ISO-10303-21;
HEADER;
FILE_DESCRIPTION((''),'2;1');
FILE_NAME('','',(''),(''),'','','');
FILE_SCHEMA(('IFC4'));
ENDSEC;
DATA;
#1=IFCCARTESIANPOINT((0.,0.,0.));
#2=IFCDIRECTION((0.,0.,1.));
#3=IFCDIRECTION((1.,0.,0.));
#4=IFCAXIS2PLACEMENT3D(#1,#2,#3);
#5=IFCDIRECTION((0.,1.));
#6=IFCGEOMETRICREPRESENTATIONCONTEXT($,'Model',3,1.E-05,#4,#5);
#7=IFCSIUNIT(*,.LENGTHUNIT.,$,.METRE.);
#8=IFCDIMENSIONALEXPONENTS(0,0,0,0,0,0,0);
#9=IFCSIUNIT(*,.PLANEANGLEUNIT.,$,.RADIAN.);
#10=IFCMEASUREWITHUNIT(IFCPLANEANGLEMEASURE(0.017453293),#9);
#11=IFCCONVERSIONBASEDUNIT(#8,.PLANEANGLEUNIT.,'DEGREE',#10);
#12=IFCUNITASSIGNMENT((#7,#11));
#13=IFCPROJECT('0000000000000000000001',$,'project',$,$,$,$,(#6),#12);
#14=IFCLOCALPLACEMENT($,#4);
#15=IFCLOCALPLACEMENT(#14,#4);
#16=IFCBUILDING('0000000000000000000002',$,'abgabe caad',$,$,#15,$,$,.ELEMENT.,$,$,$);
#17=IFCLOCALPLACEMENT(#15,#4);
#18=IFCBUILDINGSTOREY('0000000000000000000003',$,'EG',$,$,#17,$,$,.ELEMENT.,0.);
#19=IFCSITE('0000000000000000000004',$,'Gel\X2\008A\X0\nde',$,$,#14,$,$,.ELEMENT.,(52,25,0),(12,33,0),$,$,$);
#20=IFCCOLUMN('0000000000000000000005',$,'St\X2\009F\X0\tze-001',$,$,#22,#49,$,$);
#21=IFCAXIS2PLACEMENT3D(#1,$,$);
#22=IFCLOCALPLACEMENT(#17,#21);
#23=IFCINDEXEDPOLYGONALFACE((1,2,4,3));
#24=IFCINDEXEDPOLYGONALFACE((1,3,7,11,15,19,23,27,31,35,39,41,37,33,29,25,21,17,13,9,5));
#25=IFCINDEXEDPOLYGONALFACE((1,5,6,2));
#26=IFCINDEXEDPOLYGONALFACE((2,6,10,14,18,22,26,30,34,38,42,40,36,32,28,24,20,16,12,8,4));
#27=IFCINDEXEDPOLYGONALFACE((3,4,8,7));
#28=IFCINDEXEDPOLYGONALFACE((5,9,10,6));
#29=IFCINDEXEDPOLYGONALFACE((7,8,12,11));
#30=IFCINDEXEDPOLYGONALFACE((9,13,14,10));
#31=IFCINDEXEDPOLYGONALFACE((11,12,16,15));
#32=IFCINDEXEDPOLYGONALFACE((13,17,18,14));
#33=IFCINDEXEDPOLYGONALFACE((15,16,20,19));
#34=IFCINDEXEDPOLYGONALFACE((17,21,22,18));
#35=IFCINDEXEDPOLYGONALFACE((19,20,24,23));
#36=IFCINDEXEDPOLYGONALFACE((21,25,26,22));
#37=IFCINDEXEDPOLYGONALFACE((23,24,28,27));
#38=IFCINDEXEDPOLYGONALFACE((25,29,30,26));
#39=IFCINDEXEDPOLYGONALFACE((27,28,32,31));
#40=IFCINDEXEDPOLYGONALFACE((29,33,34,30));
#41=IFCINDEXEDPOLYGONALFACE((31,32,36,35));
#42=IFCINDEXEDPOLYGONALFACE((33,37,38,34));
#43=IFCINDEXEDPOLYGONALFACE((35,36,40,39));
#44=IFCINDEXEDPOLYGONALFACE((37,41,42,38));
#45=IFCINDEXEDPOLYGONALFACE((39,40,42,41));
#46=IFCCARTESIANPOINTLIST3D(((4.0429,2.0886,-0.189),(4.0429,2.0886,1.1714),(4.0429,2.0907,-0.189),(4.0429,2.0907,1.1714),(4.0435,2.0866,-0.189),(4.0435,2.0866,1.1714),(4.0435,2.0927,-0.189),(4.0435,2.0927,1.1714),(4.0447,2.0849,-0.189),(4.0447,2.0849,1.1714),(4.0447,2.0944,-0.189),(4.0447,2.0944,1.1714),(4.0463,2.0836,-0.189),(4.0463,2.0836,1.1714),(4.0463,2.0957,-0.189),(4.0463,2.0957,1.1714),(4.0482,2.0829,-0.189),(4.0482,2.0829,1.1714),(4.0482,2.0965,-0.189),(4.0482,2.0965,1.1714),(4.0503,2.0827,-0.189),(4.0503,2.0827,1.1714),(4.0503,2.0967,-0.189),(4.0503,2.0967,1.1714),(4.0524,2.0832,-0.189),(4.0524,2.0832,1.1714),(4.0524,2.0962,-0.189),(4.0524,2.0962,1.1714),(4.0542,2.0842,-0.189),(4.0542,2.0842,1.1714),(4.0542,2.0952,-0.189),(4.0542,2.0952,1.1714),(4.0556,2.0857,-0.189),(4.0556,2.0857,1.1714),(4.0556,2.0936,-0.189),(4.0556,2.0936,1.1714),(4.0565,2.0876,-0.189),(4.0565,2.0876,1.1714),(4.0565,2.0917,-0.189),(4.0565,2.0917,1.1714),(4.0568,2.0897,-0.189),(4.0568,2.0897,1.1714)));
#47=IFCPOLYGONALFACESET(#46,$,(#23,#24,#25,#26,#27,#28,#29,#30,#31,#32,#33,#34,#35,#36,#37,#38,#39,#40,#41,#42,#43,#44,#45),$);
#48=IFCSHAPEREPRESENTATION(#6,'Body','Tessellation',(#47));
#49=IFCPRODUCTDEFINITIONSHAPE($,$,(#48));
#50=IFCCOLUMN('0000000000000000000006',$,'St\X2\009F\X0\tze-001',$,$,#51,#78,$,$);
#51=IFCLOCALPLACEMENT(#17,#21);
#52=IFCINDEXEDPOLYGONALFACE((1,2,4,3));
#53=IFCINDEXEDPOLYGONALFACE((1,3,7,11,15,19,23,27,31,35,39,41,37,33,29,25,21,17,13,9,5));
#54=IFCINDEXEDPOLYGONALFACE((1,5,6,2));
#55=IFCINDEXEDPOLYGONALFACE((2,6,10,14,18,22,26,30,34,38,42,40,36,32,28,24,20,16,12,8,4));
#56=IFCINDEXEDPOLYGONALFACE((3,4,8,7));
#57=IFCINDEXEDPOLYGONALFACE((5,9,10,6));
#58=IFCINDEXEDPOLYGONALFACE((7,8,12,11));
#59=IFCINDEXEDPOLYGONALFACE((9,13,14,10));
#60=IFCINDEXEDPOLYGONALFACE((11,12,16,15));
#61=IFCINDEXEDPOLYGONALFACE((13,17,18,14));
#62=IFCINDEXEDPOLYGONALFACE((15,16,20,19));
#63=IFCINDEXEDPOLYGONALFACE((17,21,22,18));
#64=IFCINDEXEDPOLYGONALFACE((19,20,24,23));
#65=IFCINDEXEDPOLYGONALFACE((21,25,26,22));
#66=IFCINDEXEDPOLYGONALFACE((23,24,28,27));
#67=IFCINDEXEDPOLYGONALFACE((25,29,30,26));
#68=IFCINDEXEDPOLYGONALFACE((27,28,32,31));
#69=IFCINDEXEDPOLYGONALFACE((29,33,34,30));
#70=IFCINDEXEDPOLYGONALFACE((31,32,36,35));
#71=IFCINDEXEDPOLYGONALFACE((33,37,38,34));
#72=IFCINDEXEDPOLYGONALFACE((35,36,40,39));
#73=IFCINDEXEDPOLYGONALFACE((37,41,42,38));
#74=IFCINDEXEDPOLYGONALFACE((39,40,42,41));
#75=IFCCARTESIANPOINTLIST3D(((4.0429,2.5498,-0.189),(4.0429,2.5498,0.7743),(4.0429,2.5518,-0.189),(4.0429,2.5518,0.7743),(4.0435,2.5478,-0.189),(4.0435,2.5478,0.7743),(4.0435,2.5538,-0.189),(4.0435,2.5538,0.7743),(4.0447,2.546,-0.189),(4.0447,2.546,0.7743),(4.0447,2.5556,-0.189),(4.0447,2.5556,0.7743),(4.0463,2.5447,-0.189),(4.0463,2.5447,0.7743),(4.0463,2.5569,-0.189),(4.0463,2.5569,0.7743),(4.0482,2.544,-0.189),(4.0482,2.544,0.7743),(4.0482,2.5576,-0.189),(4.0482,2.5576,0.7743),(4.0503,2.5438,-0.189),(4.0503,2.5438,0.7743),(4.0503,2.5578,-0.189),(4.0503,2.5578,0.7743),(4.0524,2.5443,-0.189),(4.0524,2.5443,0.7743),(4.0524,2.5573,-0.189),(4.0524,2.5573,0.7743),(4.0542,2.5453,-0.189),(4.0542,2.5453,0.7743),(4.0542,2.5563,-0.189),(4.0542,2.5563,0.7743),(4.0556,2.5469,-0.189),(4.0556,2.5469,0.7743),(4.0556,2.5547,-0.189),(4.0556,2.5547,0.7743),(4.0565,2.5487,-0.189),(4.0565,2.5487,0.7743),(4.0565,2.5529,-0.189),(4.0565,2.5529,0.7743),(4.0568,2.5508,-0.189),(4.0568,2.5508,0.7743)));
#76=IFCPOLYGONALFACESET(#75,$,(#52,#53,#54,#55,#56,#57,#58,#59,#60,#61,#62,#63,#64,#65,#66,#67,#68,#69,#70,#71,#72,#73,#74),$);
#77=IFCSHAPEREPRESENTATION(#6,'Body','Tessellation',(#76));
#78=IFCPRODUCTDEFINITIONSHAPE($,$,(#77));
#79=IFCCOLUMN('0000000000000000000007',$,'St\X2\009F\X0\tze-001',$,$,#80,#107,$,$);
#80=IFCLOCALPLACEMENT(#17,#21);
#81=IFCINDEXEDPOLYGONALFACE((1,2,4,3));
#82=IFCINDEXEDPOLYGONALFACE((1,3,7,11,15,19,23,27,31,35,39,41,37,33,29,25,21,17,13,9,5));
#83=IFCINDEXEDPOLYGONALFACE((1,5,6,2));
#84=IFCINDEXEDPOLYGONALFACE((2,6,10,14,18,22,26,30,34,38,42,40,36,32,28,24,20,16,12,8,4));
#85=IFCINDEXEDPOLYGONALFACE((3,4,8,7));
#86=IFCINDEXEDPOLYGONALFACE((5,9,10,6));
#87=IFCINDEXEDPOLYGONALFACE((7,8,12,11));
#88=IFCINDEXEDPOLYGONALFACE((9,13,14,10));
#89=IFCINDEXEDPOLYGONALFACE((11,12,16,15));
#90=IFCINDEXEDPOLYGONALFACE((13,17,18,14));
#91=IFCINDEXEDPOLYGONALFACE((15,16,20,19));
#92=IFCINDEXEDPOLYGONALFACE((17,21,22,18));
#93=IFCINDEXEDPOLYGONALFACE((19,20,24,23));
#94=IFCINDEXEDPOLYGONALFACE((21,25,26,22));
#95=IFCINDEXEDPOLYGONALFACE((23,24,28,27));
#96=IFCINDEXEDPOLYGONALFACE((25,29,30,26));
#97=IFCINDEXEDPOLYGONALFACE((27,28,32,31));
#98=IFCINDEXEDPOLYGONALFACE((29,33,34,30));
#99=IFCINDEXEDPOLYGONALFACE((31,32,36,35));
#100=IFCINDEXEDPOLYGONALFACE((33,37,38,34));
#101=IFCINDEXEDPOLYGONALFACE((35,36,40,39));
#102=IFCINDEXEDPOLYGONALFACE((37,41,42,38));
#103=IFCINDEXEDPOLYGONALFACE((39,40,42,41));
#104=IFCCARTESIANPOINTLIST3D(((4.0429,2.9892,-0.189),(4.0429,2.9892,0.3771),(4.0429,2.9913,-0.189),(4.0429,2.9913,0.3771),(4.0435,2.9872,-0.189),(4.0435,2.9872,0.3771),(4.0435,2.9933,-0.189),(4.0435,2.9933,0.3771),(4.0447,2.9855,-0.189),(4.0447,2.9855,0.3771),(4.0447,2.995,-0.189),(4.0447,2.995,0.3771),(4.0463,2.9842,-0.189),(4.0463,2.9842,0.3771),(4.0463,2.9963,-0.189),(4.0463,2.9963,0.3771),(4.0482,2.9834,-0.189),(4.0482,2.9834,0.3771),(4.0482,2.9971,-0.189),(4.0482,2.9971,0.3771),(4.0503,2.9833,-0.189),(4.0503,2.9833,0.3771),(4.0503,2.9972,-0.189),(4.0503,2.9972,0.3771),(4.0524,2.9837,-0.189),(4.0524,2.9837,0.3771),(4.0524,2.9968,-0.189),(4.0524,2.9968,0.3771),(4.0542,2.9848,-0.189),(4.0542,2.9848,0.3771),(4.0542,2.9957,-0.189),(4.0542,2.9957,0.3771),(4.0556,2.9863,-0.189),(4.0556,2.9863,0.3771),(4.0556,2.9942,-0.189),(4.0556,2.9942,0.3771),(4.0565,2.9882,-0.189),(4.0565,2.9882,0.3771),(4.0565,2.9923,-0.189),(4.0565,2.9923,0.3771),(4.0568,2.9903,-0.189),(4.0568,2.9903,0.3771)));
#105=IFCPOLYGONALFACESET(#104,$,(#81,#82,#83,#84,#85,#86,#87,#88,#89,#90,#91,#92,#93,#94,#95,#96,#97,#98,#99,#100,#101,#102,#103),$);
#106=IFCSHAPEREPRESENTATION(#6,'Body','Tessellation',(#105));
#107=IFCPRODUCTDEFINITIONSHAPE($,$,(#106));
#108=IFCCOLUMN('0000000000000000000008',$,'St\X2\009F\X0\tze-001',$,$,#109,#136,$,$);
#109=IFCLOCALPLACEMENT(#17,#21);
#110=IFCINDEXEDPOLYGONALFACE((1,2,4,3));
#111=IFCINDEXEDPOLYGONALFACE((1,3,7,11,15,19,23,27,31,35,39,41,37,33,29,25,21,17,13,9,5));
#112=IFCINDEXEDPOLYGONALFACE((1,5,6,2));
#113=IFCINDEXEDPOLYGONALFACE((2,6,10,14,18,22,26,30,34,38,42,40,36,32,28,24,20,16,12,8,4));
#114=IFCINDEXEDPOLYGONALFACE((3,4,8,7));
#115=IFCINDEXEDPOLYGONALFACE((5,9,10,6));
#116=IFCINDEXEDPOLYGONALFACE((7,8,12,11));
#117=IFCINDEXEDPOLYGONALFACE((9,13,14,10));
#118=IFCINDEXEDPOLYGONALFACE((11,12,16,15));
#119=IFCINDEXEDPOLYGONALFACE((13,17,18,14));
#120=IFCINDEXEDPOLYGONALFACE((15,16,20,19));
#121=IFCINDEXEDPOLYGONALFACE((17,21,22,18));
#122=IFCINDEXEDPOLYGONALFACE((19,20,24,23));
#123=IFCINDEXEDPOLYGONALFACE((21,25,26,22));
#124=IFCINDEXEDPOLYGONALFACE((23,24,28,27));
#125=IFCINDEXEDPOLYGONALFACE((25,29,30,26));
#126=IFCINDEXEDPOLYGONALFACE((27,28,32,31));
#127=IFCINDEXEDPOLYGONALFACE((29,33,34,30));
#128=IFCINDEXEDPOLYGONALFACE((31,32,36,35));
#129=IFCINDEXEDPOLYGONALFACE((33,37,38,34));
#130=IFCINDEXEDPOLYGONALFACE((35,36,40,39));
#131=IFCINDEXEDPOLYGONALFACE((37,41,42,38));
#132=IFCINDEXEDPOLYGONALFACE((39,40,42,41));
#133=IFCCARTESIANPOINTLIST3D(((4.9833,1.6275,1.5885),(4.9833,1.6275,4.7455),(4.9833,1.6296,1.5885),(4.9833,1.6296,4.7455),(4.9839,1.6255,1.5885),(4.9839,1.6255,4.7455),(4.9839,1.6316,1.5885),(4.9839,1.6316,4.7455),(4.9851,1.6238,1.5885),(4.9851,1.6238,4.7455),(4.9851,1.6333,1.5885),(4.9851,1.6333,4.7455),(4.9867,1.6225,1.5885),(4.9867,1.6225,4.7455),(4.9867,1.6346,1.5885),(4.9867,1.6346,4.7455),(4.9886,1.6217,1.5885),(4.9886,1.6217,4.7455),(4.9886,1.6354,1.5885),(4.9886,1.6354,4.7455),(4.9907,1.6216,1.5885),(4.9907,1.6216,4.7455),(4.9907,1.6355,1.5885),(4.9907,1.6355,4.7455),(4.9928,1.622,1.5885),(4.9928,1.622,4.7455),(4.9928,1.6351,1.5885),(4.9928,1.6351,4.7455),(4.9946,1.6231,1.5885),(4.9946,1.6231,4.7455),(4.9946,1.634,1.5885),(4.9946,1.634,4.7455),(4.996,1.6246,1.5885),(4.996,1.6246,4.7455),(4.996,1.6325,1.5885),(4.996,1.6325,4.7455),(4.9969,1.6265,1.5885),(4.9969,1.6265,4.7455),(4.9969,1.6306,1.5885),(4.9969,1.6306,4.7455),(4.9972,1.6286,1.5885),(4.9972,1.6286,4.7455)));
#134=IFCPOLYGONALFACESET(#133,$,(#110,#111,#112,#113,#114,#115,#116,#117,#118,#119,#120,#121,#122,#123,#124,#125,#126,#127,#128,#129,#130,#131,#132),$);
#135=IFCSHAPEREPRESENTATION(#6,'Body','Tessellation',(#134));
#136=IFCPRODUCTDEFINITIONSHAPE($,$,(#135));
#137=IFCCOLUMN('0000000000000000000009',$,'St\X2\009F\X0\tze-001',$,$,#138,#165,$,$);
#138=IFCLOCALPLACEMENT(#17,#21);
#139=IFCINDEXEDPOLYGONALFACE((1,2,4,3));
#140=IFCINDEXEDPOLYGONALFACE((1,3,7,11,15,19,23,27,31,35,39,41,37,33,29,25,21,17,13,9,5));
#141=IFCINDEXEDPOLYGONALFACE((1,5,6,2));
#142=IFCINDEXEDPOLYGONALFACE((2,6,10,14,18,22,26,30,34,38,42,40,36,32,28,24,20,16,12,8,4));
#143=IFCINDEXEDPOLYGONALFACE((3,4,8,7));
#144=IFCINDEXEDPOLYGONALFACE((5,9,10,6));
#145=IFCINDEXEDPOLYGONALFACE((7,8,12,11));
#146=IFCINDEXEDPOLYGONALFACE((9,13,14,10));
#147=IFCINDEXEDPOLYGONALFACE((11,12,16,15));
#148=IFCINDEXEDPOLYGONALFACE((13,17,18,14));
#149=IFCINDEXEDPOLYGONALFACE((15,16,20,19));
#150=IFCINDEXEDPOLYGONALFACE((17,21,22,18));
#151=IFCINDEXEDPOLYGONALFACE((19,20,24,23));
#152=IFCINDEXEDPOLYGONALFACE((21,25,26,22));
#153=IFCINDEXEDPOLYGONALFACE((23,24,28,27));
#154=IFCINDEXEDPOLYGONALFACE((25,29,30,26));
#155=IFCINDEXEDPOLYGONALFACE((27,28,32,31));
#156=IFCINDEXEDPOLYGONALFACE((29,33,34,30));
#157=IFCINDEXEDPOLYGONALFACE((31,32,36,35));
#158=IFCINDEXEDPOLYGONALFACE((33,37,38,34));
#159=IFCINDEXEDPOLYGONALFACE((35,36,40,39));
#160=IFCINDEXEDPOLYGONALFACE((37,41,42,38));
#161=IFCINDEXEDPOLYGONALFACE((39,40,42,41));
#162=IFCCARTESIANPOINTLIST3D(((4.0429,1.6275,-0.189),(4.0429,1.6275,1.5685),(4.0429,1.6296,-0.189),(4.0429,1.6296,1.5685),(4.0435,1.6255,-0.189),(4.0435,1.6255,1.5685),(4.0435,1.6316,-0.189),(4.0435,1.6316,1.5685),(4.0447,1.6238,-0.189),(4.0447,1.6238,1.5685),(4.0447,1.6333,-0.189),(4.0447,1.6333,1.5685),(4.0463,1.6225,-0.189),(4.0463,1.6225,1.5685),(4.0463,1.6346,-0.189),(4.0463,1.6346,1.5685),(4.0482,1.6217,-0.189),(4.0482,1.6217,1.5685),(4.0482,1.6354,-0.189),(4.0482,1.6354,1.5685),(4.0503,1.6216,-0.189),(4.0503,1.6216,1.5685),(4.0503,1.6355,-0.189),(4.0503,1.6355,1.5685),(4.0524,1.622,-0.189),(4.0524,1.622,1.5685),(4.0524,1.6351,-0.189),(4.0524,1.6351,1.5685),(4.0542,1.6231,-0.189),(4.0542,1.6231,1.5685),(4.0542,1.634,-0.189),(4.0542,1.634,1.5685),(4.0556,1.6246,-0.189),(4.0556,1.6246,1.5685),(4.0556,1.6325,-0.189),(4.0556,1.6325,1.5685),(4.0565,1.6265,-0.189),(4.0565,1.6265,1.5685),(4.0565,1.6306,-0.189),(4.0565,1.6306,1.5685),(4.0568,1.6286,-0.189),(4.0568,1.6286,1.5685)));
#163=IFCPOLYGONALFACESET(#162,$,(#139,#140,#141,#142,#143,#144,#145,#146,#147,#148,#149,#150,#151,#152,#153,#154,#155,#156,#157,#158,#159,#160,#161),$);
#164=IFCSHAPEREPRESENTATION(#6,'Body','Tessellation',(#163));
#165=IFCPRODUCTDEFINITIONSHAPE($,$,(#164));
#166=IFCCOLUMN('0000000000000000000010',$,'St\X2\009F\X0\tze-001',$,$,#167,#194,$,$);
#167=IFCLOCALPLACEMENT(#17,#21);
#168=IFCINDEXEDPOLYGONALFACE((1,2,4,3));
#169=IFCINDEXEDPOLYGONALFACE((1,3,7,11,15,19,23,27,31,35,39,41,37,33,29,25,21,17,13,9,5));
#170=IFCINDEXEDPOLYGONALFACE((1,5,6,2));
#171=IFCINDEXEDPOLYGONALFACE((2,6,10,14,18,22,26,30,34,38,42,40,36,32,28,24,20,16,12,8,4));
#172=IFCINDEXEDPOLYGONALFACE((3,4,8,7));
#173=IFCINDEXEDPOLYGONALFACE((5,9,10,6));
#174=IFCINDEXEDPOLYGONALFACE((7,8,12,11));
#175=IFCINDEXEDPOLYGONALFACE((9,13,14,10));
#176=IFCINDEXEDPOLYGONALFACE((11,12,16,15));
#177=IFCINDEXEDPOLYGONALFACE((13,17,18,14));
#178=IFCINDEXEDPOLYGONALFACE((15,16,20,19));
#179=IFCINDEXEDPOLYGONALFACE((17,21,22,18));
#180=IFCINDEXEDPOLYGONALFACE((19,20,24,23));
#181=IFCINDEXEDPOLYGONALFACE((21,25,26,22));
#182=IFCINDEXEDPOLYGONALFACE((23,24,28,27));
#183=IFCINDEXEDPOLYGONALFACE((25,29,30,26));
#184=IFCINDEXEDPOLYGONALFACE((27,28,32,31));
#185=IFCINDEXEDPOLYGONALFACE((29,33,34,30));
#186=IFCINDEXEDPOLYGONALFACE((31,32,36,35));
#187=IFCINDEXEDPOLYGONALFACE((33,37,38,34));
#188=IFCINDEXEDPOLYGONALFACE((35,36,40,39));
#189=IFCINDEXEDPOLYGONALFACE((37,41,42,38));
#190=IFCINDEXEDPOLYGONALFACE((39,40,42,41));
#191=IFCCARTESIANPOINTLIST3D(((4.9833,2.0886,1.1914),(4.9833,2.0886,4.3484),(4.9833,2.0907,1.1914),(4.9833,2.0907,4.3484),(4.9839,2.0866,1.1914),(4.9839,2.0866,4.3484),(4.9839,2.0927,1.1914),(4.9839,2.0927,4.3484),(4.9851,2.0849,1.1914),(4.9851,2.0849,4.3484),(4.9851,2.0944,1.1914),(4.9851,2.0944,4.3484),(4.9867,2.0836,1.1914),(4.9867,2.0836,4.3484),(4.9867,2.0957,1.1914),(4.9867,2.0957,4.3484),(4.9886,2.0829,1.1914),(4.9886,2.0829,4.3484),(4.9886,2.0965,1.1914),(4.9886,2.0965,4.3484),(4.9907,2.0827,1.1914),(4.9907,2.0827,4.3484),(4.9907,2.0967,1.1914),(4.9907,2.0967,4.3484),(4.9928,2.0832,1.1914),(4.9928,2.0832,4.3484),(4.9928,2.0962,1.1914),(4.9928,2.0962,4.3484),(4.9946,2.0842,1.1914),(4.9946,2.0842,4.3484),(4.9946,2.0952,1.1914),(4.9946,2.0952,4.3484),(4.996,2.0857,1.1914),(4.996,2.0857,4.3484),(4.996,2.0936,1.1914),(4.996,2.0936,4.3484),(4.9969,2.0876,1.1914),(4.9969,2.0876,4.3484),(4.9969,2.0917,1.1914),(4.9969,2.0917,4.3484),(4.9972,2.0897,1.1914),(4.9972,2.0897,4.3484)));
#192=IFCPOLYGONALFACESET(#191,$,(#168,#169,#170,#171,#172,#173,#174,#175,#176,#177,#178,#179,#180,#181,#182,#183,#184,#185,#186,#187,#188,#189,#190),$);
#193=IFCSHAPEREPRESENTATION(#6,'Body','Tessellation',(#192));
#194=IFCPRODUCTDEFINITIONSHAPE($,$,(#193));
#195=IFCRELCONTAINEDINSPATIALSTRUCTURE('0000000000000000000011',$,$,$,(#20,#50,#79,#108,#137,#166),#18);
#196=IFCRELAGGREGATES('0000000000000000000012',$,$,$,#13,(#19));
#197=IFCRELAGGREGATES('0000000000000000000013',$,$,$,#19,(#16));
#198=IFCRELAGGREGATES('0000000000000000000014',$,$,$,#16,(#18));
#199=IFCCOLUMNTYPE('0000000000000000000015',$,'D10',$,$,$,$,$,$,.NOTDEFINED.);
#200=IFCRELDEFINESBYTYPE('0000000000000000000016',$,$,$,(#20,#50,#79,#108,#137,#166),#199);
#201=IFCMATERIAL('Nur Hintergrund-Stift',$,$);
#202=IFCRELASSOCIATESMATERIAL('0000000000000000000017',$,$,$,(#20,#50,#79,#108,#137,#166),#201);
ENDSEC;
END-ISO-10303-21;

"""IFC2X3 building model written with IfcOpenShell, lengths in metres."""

from ifc_helpers import new_model, entity, si_unit, converted_unit, direction, frame, origin_with_axes, origin_2d_with_axis, place, context, project, spatial, circle, extrude, material, type_object, element, save


model = new_model("IFC2X3")

# Units and contexts
model_context = context("Model", 3, precision=1e-05, world=origin_with_axes(), true_north=direction((0.0, 1.0)))
ifc_project = project(units=[si_unit("LENGTHUNIT", "METRE"), converted_unit("PLANEANGLEUNIT", "DEGREE", entity("IfcPlaneAngleMeasure", 0.017453293), si_unit("PLANEANGLEUNIT", "RADIAN"), dimensions=[0, 0, 0, 0, 0, 0, 0])], contexts=[model_context])

# Site, building, storey
site_placement = place(None, origin_with_axes())
site = spatial("IfcSite", under=ifc_project, at=site_placement, Name="Gel\u008ande", CompositionType="ELEMENT", RefLatitude=(52, 25, 0), RefLongitude=(12, 33, 0))
building_placement = place(site_placement, origin_with_axes())
building = spatial("IfcBuilding", under=site, at=building_placement, Name="abgabe caad", CompositionType="ELEMENT")
storey_placement = place(building_placement, origin_with_axes())
storey = spatial("IfcBuildingStorey", under=building, at=storey_placement, Name="EG", CompositionType="ELEMENT", Elevation=0.0)

# Columns
ifc_material_1 = material(Name="Nur Hintergrund-Stift")
column_type = type_object("IfcColumnType", Name="D10", PredefinedType="NOTDEFINED")
column_1_placement = place(storey_placement, frame((4.0498, 2.0897, -0.189), z_axis=(0.0, 0.0, 1.0), x_axis=(1.0, 0.0, 0.0)))
element("IfcColumn", 1, at=column_1_placement, inside=storey, type_object=column_type, material=ifc_material_1, Name="St\u009ftze-001", context=model_context, shape_type="SweptSolid", body=[
    extrude(circle(Radius=0.007, at=origin_2d_with_axis()), origin_with_axes(), (0.0, 0.0, 1.0), 1.3604),
])
column_2_placement = place(storey_placement, frame((4.0498, 2.5508, -0.189), z_axis=(0.0, 0.0, 1.0), x_axis=(1.0, 0.0, 0.0)))
element("IfcColumn", 2, at=column_2_placement, inside=storey, type_object=column_type, material=ifc_material_1, Name="St\u009ftze-001", context=model_context, shape_type="SweptSolid", body=[
    extrude(circle(Radius=0.007, at=origin_2d_with_axis()), origin_with_axes(), (0.0, 0.0, 1.0), 0.9633),
])
column_3_placement = place(storey_placement, frame((4.0498, 2.9903, -0.189), z_axis=(0.0, 0.0, 1.0), x_axis=(1.0, 0.0, 0.0)))
element("IfcColumn", 3, at=column_3_placement, inside=storey, type_object=column_type, material=ifc_material_1, Name="St\u009ftze-001", context=model_context, shape_type="SweptSolid", body=[
    extrude(circle(Radius=0.007, at=origin_2d_with_axis()), origin_with_axes(), (0.0, 0.0, 1.0), 0.5661),
])
column_4_placement = place(storey_placement, frame((4.9902, 1.6286, 1.5885), z_axis=(0.0, 0.0, 1.0), x_axis=(1.0, 0.0, 0.0)))
element("IfcColumn", 4, at=column_4_placement, inside=storey, type_object=column_type, material=ifc_material_1, Name="St\u009ftze-001", context=model_context, shape_type="SweptSolid", body=[
    extrude(circle(Radius=0.007, at=origin_2d_with_axis()), origin_with_axes(), (0.0, 0.0, 1.0), 3.157),
])
column_5_placement = place(storey_placement, frame((4.0498, 1.6286, -0.189), z_axis=(0.0, 0.0, 1.0), x_axis=(1.0, 0.0, 0.0)))
element("IfcColumn", 5, at=column_5_placement, inside=storey, type_object=column_type, material=ifc_material_1, Name="St\u009ftze-001", context=model_context, shape_type="SweptSolid", body=[
    extrude(circle(Radius=0.007, at=origin_2d_with_axis()), origin_with_axes(), (0.0, 0.0, 1.0), 1.7575),
])
for number, where, z_axis, x_axis, name in (
    (6, (4.9902, 2.0897, 1.1914), (0.0, 0.0, 1.0), (1.0, 0.0, 0.0), "St\u009ftze-001"),
):
    element("IfcColumn", number, at=place(storey_placement, frame(where, z_axis=z_axis, x_axis=x_axis)), inside=storey, type_object=column_type, material=ifc_material_1, Name=name, context=model_context, shape_type="SweptSolid", body=[
        extrude(circle(Radius=0.007, at=origin_2d_with_axis()), origin_with_axes(), (0.0, 0.0, 1.0), 3.157),
    ])

save(model, "model.ifc")
